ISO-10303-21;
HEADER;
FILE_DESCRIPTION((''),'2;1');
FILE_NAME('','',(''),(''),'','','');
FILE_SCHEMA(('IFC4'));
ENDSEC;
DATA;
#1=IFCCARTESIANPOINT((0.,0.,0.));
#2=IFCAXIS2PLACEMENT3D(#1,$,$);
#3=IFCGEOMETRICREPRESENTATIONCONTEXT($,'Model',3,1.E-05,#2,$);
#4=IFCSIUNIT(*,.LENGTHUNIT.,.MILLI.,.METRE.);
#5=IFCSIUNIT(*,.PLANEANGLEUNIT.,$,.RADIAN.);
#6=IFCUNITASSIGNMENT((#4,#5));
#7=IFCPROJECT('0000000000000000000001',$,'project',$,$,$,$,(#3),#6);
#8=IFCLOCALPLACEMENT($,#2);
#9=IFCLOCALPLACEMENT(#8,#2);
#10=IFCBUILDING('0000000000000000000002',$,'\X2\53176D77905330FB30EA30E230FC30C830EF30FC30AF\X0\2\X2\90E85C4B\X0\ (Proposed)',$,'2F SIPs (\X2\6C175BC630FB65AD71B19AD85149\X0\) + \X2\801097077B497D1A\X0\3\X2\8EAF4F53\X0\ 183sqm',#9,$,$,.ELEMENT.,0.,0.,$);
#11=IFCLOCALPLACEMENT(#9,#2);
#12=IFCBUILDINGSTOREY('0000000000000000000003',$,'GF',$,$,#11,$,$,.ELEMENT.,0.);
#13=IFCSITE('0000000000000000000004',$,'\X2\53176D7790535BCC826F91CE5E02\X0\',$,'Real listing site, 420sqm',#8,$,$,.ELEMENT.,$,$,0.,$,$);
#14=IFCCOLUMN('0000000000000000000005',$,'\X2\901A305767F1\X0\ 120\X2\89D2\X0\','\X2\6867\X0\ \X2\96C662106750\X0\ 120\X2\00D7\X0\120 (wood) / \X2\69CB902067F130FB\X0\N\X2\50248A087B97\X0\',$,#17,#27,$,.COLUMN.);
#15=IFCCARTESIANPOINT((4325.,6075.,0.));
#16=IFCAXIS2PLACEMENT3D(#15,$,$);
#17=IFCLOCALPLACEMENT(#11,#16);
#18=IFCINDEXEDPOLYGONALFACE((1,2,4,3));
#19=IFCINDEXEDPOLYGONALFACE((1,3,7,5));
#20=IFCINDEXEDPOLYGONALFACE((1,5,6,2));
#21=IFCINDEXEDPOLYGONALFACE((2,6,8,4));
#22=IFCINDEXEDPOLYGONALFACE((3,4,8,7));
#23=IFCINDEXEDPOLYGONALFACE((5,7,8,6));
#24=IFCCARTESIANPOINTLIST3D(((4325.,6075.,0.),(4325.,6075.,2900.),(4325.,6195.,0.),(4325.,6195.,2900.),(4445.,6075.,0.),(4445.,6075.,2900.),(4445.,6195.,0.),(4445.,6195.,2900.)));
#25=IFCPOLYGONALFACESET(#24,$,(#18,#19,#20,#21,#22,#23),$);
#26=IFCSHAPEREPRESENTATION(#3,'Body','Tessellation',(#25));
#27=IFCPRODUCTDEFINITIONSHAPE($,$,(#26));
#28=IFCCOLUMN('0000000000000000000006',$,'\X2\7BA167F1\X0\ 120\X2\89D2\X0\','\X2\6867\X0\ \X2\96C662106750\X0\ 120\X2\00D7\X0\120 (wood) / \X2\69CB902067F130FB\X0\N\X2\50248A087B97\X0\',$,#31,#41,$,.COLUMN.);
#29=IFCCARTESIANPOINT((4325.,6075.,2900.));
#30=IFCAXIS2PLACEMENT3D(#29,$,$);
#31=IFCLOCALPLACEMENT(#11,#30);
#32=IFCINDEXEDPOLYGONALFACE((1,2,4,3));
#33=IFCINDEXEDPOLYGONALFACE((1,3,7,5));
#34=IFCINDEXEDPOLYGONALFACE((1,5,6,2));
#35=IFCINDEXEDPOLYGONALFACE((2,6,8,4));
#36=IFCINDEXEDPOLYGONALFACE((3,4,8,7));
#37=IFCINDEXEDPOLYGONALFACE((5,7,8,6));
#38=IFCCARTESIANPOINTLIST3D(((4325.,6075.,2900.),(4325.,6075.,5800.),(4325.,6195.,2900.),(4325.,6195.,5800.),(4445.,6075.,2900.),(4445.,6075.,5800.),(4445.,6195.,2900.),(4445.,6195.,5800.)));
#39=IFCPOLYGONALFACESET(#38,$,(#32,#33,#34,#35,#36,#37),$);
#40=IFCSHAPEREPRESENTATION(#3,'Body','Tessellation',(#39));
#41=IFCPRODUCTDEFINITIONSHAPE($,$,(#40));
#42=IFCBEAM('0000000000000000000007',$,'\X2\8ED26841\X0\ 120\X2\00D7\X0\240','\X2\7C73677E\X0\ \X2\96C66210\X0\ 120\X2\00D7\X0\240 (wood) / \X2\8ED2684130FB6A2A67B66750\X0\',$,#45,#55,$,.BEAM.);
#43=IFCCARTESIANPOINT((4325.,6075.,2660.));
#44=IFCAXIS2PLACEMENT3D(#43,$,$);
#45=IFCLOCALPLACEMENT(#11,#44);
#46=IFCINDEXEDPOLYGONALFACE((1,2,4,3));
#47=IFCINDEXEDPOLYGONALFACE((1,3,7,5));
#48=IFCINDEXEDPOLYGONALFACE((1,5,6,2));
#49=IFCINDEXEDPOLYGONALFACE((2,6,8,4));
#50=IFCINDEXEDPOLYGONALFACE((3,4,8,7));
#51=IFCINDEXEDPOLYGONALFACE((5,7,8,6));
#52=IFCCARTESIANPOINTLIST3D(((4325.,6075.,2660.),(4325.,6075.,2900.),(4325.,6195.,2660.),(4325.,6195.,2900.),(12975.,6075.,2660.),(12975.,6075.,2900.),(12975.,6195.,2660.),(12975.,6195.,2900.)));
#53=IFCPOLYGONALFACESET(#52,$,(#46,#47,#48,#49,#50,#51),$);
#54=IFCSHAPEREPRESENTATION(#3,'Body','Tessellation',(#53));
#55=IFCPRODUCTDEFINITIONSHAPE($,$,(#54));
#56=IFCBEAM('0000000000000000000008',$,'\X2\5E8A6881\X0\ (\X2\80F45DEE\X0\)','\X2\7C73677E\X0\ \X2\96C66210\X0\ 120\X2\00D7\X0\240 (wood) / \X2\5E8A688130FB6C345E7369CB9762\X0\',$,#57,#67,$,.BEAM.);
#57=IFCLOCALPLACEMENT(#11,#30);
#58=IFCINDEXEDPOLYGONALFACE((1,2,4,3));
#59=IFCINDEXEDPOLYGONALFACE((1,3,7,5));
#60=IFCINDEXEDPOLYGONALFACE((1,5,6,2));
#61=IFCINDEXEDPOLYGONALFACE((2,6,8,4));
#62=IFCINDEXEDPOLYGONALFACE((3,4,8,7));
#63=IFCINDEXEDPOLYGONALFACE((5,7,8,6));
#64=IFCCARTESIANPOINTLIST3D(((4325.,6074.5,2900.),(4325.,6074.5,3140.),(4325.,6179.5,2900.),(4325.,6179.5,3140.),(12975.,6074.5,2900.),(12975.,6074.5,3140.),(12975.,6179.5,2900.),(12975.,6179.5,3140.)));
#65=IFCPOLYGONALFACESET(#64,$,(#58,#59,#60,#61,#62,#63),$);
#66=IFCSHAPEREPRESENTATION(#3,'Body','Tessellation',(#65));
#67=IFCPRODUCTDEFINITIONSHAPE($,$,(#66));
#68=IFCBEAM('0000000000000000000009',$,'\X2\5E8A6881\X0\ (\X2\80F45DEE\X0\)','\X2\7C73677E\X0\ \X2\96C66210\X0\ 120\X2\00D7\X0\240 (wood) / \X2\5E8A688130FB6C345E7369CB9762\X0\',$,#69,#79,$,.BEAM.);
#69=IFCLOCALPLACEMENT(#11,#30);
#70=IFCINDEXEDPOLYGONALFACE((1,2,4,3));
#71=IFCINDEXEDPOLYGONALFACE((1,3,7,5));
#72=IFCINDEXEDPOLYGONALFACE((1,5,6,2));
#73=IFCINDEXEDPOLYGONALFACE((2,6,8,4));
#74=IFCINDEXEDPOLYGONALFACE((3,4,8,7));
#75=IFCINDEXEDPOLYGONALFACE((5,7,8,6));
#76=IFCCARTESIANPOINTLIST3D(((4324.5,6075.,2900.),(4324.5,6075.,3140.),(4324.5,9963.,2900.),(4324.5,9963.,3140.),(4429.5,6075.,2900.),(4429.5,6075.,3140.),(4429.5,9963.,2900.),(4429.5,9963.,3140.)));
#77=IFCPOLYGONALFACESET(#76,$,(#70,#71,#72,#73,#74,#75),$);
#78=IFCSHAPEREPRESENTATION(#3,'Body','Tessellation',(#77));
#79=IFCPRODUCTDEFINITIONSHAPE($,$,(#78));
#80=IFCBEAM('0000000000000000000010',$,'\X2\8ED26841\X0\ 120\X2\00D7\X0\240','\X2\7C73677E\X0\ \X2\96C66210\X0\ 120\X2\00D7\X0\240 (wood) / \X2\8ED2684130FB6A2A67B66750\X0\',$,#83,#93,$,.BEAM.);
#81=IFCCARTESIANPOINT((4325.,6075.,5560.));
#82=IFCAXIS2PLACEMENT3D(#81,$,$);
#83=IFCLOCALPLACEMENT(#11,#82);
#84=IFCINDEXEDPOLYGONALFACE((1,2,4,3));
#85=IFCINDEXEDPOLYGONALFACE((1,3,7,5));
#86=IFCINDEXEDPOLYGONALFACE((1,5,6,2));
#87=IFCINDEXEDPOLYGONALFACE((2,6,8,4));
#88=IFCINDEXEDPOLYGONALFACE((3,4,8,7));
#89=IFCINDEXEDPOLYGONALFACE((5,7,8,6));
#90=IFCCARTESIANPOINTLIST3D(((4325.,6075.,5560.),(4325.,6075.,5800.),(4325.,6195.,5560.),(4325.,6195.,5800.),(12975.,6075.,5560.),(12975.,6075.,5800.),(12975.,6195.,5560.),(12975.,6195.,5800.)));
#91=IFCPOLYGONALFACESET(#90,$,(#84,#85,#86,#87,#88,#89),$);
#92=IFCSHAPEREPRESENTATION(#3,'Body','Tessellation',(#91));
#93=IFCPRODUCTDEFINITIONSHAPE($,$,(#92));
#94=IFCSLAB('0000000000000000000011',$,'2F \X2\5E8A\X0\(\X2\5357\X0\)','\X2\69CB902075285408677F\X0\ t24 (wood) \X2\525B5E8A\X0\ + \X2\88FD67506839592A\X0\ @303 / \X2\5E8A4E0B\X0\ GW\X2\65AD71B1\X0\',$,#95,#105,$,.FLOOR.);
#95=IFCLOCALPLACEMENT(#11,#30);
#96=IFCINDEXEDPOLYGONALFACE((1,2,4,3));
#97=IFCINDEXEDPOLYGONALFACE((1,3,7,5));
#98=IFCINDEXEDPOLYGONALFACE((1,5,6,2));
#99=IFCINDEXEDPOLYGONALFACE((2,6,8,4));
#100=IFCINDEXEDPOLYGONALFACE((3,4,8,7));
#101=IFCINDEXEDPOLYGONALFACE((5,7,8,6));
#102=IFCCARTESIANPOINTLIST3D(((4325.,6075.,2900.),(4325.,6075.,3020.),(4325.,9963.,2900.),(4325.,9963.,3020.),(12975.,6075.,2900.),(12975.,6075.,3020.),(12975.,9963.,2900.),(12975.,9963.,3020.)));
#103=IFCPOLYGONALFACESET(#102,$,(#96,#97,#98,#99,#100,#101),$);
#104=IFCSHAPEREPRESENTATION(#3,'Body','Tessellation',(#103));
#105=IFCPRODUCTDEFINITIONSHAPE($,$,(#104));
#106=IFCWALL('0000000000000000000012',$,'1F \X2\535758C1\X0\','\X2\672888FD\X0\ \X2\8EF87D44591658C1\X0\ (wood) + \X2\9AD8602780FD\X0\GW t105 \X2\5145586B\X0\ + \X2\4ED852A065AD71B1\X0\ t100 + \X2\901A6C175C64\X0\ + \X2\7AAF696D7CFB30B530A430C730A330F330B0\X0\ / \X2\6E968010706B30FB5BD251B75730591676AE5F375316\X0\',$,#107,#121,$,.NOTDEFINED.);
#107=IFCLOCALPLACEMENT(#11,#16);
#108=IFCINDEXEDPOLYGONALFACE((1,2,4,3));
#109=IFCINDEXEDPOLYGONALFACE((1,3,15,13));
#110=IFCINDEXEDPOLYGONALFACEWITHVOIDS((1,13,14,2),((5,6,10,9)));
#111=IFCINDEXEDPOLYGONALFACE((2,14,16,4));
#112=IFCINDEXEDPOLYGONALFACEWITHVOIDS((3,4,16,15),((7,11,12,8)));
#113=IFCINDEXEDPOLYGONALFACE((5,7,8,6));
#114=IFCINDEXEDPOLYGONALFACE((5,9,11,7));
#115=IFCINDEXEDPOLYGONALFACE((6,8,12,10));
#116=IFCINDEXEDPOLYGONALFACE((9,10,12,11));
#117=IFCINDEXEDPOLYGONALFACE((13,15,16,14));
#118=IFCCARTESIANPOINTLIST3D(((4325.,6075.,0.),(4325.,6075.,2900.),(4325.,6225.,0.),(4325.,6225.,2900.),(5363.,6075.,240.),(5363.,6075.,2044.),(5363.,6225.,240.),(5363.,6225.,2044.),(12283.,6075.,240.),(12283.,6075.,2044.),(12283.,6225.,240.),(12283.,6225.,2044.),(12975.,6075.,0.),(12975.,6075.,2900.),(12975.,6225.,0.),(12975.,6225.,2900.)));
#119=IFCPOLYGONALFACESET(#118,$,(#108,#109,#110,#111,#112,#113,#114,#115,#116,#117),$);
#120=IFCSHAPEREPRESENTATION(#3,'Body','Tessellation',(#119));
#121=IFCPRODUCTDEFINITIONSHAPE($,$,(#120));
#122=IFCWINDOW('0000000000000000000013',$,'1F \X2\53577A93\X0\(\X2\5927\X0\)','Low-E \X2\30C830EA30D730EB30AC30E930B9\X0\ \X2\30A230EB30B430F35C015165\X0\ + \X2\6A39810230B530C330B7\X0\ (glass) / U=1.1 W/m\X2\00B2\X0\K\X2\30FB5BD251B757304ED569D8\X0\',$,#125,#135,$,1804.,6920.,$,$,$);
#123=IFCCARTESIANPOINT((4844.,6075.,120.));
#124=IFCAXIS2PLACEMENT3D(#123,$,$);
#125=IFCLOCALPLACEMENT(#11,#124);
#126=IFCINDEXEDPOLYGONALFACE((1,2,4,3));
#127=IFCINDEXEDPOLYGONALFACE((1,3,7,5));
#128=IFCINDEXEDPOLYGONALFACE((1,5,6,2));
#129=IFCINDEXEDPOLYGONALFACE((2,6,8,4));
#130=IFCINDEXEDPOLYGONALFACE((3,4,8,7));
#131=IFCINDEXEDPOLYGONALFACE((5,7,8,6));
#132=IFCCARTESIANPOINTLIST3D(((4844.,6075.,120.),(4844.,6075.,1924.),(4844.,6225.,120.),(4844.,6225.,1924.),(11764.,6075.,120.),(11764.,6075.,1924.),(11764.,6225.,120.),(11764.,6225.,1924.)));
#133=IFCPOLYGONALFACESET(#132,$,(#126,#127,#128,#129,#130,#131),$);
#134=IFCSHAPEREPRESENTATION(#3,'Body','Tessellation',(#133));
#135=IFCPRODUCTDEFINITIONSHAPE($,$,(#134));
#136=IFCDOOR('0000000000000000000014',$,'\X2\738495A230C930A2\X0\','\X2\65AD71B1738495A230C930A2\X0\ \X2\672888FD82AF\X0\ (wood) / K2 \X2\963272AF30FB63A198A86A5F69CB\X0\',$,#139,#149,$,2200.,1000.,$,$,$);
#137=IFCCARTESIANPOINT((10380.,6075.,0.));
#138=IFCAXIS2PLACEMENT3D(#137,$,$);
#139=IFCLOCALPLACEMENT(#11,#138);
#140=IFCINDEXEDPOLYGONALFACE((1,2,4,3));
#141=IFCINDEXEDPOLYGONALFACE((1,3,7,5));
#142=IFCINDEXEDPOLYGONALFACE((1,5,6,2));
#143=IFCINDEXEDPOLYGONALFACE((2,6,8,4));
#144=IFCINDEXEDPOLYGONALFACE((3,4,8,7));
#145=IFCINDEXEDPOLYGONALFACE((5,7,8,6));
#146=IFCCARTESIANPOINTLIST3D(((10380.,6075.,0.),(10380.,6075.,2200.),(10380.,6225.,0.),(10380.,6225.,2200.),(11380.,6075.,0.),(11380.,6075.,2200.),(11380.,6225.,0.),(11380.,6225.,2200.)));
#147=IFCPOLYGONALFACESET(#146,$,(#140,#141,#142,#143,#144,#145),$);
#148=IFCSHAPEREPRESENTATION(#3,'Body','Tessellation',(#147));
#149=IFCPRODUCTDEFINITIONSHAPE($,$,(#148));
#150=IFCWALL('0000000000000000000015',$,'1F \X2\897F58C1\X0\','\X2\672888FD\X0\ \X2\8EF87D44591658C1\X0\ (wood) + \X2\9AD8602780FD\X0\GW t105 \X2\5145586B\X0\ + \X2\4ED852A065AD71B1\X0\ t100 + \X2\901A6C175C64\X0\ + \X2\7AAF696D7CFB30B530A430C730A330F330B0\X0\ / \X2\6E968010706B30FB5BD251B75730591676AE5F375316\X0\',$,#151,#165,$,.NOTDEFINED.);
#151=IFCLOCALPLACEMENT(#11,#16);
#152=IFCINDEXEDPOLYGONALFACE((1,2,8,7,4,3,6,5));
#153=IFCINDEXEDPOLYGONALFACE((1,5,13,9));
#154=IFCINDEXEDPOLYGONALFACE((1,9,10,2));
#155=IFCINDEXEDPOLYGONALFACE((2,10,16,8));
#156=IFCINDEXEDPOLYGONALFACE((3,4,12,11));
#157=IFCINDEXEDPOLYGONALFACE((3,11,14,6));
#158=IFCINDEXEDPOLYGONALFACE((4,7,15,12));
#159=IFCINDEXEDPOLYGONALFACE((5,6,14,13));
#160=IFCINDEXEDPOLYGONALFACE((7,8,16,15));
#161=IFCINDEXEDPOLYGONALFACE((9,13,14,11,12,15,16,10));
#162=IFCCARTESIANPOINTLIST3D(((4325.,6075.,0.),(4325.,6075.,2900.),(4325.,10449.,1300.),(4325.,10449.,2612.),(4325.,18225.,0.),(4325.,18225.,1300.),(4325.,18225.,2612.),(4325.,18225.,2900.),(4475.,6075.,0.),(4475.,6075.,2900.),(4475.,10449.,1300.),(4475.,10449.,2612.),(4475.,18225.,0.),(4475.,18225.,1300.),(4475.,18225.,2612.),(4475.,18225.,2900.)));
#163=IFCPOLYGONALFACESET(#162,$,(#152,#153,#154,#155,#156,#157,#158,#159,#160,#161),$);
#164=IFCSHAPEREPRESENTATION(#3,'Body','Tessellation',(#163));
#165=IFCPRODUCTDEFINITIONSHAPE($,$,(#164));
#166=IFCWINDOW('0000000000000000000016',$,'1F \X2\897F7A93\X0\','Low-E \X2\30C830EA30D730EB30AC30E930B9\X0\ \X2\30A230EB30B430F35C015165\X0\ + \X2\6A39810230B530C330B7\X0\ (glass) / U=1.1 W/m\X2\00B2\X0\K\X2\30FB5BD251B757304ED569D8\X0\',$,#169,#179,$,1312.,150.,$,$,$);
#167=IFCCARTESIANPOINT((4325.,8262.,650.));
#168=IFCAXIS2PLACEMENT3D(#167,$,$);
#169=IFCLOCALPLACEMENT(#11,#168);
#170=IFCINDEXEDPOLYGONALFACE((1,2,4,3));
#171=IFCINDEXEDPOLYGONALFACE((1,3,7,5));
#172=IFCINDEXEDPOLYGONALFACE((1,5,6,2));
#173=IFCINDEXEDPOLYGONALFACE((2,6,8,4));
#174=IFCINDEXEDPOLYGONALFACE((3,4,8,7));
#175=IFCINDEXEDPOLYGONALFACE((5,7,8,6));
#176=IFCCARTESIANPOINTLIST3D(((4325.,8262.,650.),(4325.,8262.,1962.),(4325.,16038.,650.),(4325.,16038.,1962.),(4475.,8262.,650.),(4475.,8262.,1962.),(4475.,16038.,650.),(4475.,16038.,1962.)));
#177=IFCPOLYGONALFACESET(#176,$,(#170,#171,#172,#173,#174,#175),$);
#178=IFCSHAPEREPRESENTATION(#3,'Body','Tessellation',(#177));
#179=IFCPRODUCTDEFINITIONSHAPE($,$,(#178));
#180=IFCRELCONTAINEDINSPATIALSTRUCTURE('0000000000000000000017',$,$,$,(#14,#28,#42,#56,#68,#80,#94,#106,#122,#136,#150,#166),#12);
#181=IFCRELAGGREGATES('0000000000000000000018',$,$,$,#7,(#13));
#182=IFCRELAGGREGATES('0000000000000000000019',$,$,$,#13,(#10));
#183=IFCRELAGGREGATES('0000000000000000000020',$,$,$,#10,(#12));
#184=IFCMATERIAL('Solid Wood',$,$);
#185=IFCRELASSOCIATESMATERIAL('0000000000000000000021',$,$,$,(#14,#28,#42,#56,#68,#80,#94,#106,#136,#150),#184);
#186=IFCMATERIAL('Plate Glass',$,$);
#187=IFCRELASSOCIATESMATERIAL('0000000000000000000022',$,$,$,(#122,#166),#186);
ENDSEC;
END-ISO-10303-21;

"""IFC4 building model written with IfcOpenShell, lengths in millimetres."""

from ifc_helpers import new_model, si_unit, frame, frame_2d, origin, place, context, project, spatial, rectangle, extrude, material, element, fill, save


model = new_model("IFC4")

# Units and contexts
model_context = context("Model", 3, precision=1e-05, world=origin())
ifc_project = project(units=[si_unit("LENGTHUNIT", "METRE", prefix="MILLI"), si_unit("PLANEANGLEUNIT", "RADIAN")], contexts=[model_context])

# Site, building, storey
site_placement = place(None, origin())
site = spatial("IfcSite", under=ifc_project, at=site_placement, Name="北海道富良野市", ObjectType="Real listing site, 420sqm", CompositionType="ELEMENT", RefElevation=0.0)
building_placement = place(site_placement, origin())
building = spatial("IfcBuilding", under=site, at=building_placement, Name="北海道・リモートワーク2部屋 (Proposed)", ObjectType="2F SIPs (気密・断熱高光) + 耐震等級3躯体 183sqm", CompositionType="ELEMENT", ElevationOfRefHeight=0.0, ElevationOfTerrain=0.0)
storey_placement = place(building_placement, origin())
storey = spatial("IfcBuildingStorey", under=building, at=storey_placement, Name="GF", CompositionType="ELEMENT", Elevation=0.0)

# Columns
ifc_material_1 = material(Name="Solid Wood")
column_1_placement = place(storey_placement, frame((4325.0, 6075.0, 0.0)))
element("IfcColumn", 1, at=column_1_placement, inside=storey, material=ifc_material_1, Name="通し柱 120角", Description="桧 集成材 120×120 (wood) / 構造柱・N値計算", PredefinedType="COLUMN", context=model_context, shape_type="SweptSolid", body=[
    extrude(rectangle(XDim=120.0, YDim=120.0, at=frame_2d((60.0, 60.0))), frame((4325.0, 6075.0, 0.0)), (0.0, 0.0, 1.0), 2900.0),
])
column_2_placement = place(storey_placement, frame((4325.0, 6075.0, 2900.0)))
element("IfcColumn", 2, at=column_2_placement, inside=storey, material=ifc_material_1, Name="管柱 120角", Description="桧 集成材 120×120 (wood) / 構造柱・N値計算", PredefinedType="COLUMN", context=model_context, shape_type="SweptSolid", body=[
    extrude(rectangle(XDim=120.0, YDim=120.0, at=frame_2d((60.0, 60.0))), frame((4325.0, 6075.0, 2900.0)), (0.0, 0.0, 1.0), 2900.0),
])

# Beams
beam_1_placement = place(storey_placement, frame((4325.0, 6075.0, 2660.0)))
element("IfcBeam", 3, at=beam_1_placement, inside=storey, material=ifc_material_1, Name="軒桁 120×240", Description="米松 集成 120×240 (wood) / 軒桁・横架材", PredefinedType="BEAM", context=model_context, shape_type="SweptSolid", body=[
    extrude(rectangle(XDim=8650.0, YDim=120.0, at=frame_2d((4325.0, 60.0))), frame((4325.0, 6075.0, 2660.0)), (0.0, 0.0, 1.0), 240.0),
])
beam_2_placement = place(storey_placement, frame((4325.0, 6075.0, 2900.0)))
element("IfcBeam", 4, at=beam_2_placement, inside=storey, material=ifc_material_1, Name="床梁 (胴差)", Description="米松 集成 120×240 (wood) / 床梁・水平構面", PredefinedType="BEAM", context=model_context, shape_type="SweptSolid", body=[
    extrude(rectangle(XDim=8650.0, YDim=105.0, at=frame_2d((4325.0, 52.0))), frame((4325.0, 6075.0, 2900.0)), (0.0, 0.0, 1.0), 240.0),
])
beam_3_placement = place(storey_placement, frame((4325.0, 6075.0, 2900.0)))
element("IfcBeam", 5, at=beam_3_placement, inside=storey, material=ifc_material_1, Name="床梁 (胴差)", Description="米松 集成 120×240 (wood) / 床梁・水平構面", PredefinedType="BEAM", context=model_context, shape_type="SweptSolid", body=[
    extrude(rectangle(XDim=105.0, YDim=3888.0, at=frame_2d((52.0, 1944.0))), frame((4325.0, 6075.0, 2900.0)), (0.0, 0.0, 1.0), 240.0),
])
beam_4_placement = place(storey_placement, frame((4325.0, 6075.0, 5560.0)))
element("IfcBeam", 6, at=beam_4_placement, inside=storey, material=ifc_material_1, Name="軒桁 120×240", Description="米松 集成 120×240 (wood) / 軒桁・横架材", PredefinedType="BEAM", context=model_context, shape_type="SweptSolid", body=[
    extrude(rectangle(XDim=8650.0, YDim=120.0, at=frame_2d((4325.0, 60.0))), frame((4325.0, 6075.0, 5560.0)), (0.0, 0.0, 1.0), 240.0),
])

# Slab
slab_1_placement = place(storey_placement, frame((4325.0, 6075.0, 2900.0)))
element("IfcSlab", 7, at=slab_1_placement, inside=storey, material=ifc_material_1, Name="2F 床(南)", Description="構造用合板 t24 (wood) 剛床 + 製材根太 @303 / 床下 GW断熱", PredefinedType="FLOOR", context=model_context, shape_type="SweptSolid", body=[
    extrude(rectangle(XDim=8650.0, YDim=3888.0, at=frame_2d((4325.0, 1944.0))), frame((4325.0, 6075.0, 2900.0)), (0.0, 0.0, 1.0), 120.0),
])

# Wall, openings, window, door
wall_1_placement = place(storey_placement, frame((4325.0, 6075.0, 0.0)))
wall_1 = element("IfcWall", 8, at=wall_1_placement, inside=storey, material=ifc_material_1, Name="1F 南壁", Description="木製 軸組外壁 (wood) + 高性能GW t105 充填 + 付加断熱 t100 + 通気層 + 窯業系サイディング / 準耐火・寒冷地外皮強化", PredefinedType="NOTDEFINED", context=model_context, shape_type="SweptSolid", body=[
    extrude(rectangle(XDim=8650.0, YDim=150.0, at=frame_2d((4325.0, 75.0))), frame((4325.0, 6075.0, 0.0)), (0.0, 0.0, 1.0), 2900.0),
])
opening_1_placement = place(storey_placement, frame((4844.0, 6075.0, 120.0)))
opening_1 = element("IfcOpeningElement", 9, at=opening_1_placement, cuts=wall_1, PredefinedType="NOTDEFINED", context=model_context, shape_type="SweptSolid", body=[
    extrude(rectangle(XDim=6920.0, YDim=150.0, at=frame_2d((3460.0, 75.0))), frame((4844.0, 6075.0, 120.0)), (0.0, 0.0, 1.0), 1804.0),
])
opening_2_placement = place(storey_placement, frame((10380.0, 6075.0, 0.0)))
opening_2 = element("IfcOpeningElement", 10, at=opening_2_placement, cuts=wall_1, PredefinedType="NOTDEFINED", context=model_context, shape_type="SweptSolid", body=[
    extrude(rectangle(XDim=1000.0, YDim=150.0, at=frame_2d((500.0, 75.0))), frame((10380.0, 6075.0, 0.0)), (0.0, 0.0, 1.0), 2200.0),
])
ifc_material_2 = material(Name="Plate Glass")
window_1_placement = place(storey_placement, frame((4844.0, 6075.0, 120.0)))
window_1 = element("IfcWindow", 11, at=window_1_placement, inside=storey, material=ifc_material_2, Name="1F 南窓(大)", Description="Low-E トリプルガラス アルゴン封入 + 樹脂サッシ (glass) / U=1.1 W/m²K・寒冷地仕様", OverallHeight=1804.0, OverallWidth=6920.0, context=model_context, shape_type="SweptSolid", body=[
    extrude(rectangle(XDim=6920.0, YDim=150.0, at=frame_2d((3460.0, 75.0))), frame((4844.0, 6075.0, 120.0)), (0.0, 0.0, 1.0), 1804.0),
])
fill(opening_1, window_1)
door_placement = place(storey_placement, frame((10380.0, 6075.0, 0.0)))
door = element("IfcDoor", 12, at=door_placement, inside=storey, material=ifc_material_1, Name="玄関ドア", Description="断熱玄関ドア 木製芯 (wood) / K2 防犯・採風機構", OverallHeight=2200.0, OverallWidth=1000.0, context=model_context, shape_type="SweptSolid", body=[
    extrude(rectangle(XDim=1000.0, YDim=150.0, at=frame_2d((500.0, 75.0))), frame((10380.0, 6075.0, 0.0)), (0.0, 0.0, 1.0), 2200.0),
])
fill(opening_2, door)

# Wall, opening, window
wall_2_placement = place(storey_placement, frame((4325.0, 6075.0, 0.0)))
wall_2 = element("IfcWall", 13, at=wall_2_placement, inside=storey, material=ifc_material_1, Name="1F 西壁", Description="木製 軸組外壁 (wood) + 高性能GW t105 充填 + 付加断熱 t100 + 通気層 + 窯業系サイディング / 準耐火・寒冷地外皮強化", PredefinedType="NOTDEFINED", context=model_context, shape_type="SweptSolid", body=[
    extrude(rectangle(XDim=150.0, YDim=12150.0, at=frame_2d((75.0, 6075.0))), frame((4325.0, 6075.0, 0.0)), (0.0, 0.0, 1.0), 2900.0),
])
opening_3_placement = place(storey_placement, frame((4325.0, 8262.0, 650.0)))
opening_3 = element("IfcOpeningElement", 14, at=opening_3_placement, cuts=wall_2, PredefinedType="NOTDEFINED", context=model_context, shape_type="SweptSolid", body=[
    extrude(rectangle(XDim=150.0, YDim=7776.0, at=frame_2d((75.0, 3888.0))), frame((4325.0, 8262.0, 650.0)), (0.0, 0.0, 1.0), 1312.0),
])
window_2_placement = place(storey_placement, frame((4325.0, 8262.0, 650.0)))
window_2 = element("IfcWindow", 15, at=window_2_placement, inside=storey, material=ifc_material_2, Name="1F 西窓", Description="Low-E トリプルガラス アルゴン封入 + 樹脂サッシ (glass) / U=1.1 W/m²K・寒冷地仕様", OverallHeight=1312.0, OverallWidth=150.0, context=model_context, shape_type="SweptSolid", body=[
    extrude(rectangle(XDim=150.0, YDim=7776.0, at=frame_2d((75.0, 3888.0))), frame((4325.0, 8262.0, 650.0)), (0.0, 0.0, 1.0), 1312.0),
])
fill(opening_3, window_2)

save(model, "model.ifc")
